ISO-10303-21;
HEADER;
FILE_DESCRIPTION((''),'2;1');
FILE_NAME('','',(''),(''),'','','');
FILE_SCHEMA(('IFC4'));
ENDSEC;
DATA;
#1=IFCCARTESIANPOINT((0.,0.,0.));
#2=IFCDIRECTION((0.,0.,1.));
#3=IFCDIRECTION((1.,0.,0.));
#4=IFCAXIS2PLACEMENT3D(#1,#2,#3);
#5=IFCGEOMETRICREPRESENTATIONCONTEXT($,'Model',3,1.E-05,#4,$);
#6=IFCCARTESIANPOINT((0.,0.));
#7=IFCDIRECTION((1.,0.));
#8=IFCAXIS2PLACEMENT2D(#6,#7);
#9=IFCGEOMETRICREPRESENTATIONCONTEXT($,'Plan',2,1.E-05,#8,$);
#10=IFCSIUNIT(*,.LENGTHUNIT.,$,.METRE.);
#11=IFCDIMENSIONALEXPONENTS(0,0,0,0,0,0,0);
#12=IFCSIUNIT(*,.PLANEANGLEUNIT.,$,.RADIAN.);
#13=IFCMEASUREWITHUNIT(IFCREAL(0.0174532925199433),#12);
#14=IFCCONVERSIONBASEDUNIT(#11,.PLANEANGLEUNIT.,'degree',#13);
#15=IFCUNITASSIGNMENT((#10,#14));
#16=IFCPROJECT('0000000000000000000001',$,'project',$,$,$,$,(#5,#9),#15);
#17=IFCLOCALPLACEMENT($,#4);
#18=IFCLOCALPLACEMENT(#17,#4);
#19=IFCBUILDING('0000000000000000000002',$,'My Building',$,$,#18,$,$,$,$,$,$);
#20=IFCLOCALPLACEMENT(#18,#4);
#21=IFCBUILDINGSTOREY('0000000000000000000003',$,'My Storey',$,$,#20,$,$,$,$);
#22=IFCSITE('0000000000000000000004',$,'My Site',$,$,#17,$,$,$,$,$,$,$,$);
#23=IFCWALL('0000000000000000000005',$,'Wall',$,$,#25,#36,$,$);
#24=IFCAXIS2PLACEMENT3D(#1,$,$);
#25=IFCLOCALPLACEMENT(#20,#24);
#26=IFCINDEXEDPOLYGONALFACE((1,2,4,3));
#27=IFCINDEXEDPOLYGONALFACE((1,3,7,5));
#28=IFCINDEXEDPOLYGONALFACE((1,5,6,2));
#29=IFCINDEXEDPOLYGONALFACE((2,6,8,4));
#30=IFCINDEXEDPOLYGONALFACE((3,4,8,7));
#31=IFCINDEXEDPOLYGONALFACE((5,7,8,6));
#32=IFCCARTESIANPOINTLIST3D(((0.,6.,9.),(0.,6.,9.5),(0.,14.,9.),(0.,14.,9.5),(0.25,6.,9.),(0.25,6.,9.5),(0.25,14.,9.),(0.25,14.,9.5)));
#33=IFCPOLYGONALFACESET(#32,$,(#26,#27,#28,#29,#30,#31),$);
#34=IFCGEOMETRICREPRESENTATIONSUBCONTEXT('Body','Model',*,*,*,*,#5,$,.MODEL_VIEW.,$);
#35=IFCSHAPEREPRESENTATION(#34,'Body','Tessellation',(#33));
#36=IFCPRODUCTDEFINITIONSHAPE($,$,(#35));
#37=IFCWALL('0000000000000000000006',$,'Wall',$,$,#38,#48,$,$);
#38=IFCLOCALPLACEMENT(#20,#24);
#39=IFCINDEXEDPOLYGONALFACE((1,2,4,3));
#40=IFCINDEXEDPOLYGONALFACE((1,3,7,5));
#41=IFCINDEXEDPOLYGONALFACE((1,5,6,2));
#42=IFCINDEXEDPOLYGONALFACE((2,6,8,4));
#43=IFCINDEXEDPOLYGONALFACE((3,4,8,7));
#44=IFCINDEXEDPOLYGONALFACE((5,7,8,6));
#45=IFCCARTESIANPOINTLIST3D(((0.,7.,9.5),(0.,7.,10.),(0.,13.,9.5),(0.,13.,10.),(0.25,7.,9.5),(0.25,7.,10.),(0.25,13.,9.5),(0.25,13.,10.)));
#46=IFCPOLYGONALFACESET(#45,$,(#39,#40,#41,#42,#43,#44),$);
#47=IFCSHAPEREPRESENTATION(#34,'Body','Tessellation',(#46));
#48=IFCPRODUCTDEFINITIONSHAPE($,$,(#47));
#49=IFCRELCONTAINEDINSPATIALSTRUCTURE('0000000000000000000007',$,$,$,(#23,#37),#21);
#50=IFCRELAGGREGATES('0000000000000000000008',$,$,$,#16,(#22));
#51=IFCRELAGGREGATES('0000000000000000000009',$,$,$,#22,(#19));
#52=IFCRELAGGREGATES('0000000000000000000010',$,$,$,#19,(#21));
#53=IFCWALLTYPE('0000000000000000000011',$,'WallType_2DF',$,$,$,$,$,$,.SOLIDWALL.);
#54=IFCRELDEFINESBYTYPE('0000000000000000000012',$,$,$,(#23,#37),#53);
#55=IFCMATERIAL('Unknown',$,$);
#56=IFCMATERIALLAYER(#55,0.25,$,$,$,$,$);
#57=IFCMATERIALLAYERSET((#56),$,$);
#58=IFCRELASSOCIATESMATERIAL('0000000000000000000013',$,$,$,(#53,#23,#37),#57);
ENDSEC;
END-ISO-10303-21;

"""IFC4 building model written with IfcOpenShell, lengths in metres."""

from ifc_helpers import new_model, entity, si_unit, converted_unit, frame, origin_with_axes, origin_2d_with_axis, place, context, subcontext, project, spatial, indexed_curve, outline, extrude, material, layer, layer_set, layer_usage, type_object, element, save


model = new_model("IFC4")

# Units and contexts
model_context = context("Model", 3, precision=1e-05, world=origin_with_axes())
plan_context = context("Plan", 2, precision=1e-05, world=origin_2d_with_axis())
body_context_1 = subcontext(model_context, "Body", "Model", "MODEL_VIEW")
ifc_project = project(units=[si_unit("LENGTHUNIT", "METRE"), converted_unit("PLANEANGLEUNIT", "degree", entity("IfcReal", 0.0174532925199433), si_unit("PLANEANGLEUNIT", "RADIAN"), dimensions=[0, 0, 0, 0, 0, 0, 0])], contexts=[model_context, plan_context])

# Site, building, storey
site_placement = place(None, origin_with_axes())
site = spatial("IfcSite", under=ifc_project, at=site_placement, Name="My Site")
building_placement = place(site_placement, origin_with_axes())
building = spatial("IfcBuilding", under=site, at=building_placement, Name="My Building")
storey_placement = place(building_placement, origin_with_axes())
storey = spatial("IfcBuildingStorey", under=building, at=storey_placement, Name="My Storey")

# Shared definitions
ifc_material = material(Name="Unknown")
ifc_layer = layer(ifc_material, 0.25)
ifc_layer_set = layer_set([ifc_layer])
wall_type = type_object("IfcWallType", Name="WallType_2DF", PredefinedType="SOLIDWALL", material=ifc_layer_set)

# Walls
ifc_layer_usage_1 = layer_usage(ifc_layer_set, "AXIS2", "POSITIVE", 0.0)
wall_1_placement = place(storey_placement, frame((0.25, 6.0, 9.0), z_axis=(0.0, 0.0, 1.0), x_axis=(0.0, 1.0, 0.0)))
element("IfcWall", 1, at=wall_1_placement, inside=storey, type_object=wall_type, material=ifc_layer_usage_1, Name="Wall", context=body_context_1, shape_type="SweptSolid", body=[
    extrude(outline(indexed_curve([(0.0, 0.0), (0.0, 0.25), (8.0, 0.25), (8.0, 0.0), (0.0, 0.0)], self_intersect=False)), origin_with_axes(), (0.0, 0.0, 1.0), 0.5),
])
ifc_layer_usage_2 = layer_usage(ifc_layer_set, "AXIS2", "POSITIVE", 0.0)
wall_2_placement = place(storey_placement, frame((0.25, 7.0, 9.5), z_axis=(0.0, 0.0, 1.0), x_axis=(0.0, 1.0, 0.0)))
element("IfcWall", 2, at=wall_2_placement, inside=storey, type_object=wall_type, material=ifc_layer_usage_2, Name="Wall", context=body_context_1, shape_type="SweptSolid", body=[
    extrude(outline(indexed_curve([(0.0, 0.0), (0.0, 0.25), (6.0, 0.25), (6.0, 0.0), (0.0, 0.0)], self_intersect=False)), origin_with_axes(), (0.0, 0.0, 1.0), 0.5),
])

save(model, "model.ifc")
